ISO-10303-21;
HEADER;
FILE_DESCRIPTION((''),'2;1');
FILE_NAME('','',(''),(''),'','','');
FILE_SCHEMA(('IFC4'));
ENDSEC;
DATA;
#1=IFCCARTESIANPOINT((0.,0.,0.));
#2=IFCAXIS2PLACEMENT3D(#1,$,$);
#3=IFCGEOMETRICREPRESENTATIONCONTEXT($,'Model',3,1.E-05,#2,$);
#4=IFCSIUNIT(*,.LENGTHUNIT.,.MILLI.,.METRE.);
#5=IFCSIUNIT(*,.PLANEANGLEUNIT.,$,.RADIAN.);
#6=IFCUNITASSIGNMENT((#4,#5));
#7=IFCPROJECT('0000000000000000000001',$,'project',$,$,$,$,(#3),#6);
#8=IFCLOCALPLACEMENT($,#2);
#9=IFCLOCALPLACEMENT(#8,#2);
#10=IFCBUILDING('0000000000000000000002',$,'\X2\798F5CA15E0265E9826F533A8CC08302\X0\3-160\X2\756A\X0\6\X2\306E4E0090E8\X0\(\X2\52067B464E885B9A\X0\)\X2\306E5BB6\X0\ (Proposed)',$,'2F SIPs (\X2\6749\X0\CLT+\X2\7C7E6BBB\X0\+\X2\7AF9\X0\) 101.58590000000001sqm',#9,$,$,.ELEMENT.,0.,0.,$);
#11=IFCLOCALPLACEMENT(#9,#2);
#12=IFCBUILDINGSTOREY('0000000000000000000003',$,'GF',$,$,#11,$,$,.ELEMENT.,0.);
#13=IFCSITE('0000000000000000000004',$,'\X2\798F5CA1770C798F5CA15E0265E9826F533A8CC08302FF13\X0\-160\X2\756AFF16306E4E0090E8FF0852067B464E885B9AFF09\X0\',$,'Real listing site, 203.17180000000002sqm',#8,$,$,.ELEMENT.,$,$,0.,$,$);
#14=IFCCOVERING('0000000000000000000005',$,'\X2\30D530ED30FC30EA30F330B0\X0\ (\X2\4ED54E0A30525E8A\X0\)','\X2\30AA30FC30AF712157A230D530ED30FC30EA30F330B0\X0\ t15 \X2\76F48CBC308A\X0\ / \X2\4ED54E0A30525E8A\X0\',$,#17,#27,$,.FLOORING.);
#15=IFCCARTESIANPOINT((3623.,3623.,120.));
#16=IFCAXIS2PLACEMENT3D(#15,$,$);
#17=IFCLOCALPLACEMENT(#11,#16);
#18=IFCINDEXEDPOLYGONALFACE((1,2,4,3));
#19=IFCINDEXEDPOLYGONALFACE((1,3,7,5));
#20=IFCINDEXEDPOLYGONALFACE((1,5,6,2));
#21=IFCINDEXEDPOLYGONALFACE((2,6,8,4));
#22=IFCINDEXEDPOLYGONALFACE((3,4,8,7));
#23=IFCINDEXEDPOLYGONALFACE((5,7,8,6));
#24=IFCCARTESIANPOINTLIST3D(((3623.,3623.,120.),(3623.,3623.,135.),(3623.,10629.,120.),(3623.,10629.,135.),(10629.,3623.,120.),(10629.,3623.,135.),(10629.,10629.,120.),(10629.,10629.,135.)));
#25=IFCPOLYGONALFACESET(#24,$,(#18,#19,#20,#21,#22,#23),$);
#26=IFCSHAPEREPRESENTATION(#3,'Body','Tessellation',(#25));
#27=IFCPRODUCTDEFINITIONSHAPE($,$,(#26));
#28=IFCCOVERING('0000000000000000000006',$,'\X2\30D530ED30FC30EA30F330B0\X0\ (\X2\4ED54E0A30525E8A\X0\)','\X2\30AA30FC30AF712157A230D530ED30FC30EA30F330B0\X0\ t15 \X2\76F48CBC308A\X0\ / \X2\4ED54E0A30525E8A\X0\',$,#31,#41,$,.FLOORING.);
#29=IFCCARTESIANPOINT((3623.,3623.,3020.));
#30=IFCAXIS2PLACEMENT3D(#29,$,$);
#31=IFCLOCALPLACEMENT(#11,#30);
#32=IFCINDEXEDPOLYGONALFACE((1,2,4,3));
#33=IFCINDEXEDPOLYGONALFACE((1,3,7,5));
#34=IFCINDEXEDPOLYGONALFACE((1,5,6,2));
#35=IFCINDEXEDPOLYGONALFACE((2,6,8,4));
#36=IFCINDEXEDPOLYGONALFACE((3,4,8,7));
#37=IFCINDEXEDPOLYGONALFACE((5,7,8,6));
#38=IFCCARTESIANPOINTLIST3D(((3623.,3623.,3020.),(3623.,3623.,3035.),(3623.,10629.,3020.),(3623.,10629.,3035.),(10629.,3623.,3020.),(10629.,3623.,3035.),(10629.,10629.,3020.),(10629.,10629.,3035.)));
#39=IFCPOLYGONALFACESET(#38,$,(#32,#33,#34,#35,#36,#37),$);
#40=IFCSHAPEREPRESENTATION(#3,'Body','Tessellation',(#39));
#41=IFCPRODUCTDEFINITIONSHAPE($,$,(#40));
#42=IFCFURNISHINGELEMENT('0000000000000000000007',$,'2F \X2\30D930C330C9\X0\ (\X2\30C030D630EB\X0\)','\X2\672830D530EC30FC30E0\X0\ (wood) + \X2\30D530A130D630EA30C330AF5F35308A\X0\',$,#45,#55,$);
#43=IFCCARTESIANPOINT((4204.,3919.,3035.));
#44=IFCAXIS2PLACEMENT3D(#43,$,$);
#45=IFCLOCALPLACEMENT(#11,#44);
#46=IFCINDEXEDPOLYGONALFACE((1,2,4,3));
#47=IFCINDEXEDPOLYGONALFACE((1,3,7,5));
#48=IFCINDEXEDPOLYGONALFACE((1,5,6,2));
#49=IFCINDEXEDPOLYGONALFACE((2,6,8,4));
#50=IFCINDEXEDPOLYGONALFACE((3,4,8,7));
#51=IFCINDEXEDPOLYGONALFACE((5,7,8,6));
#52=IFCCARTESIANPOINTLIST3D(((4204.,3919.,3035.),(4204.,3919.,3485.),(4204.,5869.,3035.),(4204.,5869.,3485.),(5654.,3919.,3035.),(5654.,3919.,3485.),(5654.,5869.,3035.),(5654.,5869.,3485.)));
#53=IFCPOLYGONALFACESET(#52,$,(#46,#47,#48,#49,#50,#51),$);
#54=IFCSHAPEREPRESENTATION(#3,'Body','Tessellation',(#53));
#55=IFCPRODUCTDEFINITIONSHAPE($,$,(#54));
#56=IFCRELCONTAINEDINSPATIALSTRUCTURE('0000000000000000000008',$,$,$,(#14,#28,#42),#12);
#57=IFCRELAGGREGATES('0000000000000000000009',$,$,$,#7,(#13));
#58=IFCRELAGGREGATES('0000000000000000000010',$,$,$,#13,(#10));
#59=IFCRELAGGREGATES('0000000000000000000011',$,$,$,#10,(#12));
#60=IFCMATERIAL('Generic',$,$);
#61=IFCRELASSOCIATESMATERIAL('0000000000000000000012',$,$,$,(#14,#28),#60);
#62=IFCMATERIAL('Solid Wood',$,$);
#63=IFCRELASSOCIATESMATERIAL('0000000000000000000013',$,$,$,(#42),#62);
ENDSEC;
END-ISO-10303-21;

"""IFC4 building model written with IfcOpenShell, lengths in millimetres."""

from ifc_helpers import new_model, si_unit, frame, frame_2d, origin, place, context, project, spatial, rectangle, extrude, material, element, save


model = new_model("IFC4")

# Units and contexts
model_context = context("Model", 3, precision=1e-05, world=origin())
ifc_project = project(units=[si_unit("LENGTHUNIT", "METRE", prefix="MILLI"), si_unit("PLANEANGLEUNIT", "RADIAN")], contexts=[model_context])

# Site, building, storey
site_placement = place(None, origin())
site = spatial("IfcSite", under=ifc_project, at=site_placement, Name="福岡県福岡市早良区賀茂３-160番６の一部（分筆予定）", ObjectType="Real listing site, 203.17180000000002sqm", CompositionType="ELEMENT", RefElevation=0.0)
building_placement = place(site_placement, origin())
building = spatial("IfcBuilding", under=site, at=building_placement, Name="福岡市早良区賀茂3-160番6の一部(分筆予定)の家 (Proposed)", ObjectType="2F SIPs (杉CLT+籾殻+竹) 101.58590000000001sqm", CompositionType="ELEMENT", ElevationOfRefHeight=0.0, ElevationOfTerrain=0.0)
storey_placement = place(building_placement, origin())
storey = spatial("IfcBuildingStorey", under=building, at=storey_placement, Name="GF", CompositionType="ELEMENT", Elevation=0.0)

# Shared definitions
ifc_material_1 = material(Name="Solid Wood")

# Coverings
ifc_material_2 = material(Name="Generic")
covering_1_placement = place(storey_placement, frame((3623.0, 3623.0, 120.0)))
element("IfcCovering", 1, at=covering_1_placement, inside=storey, material=ifc_material_2, Name="フローリング (仕上げ床)", Description="オーク無垢フローリング t15 直貼り / 仕上げ床", PredefinedType="FLOORING", context=model_context, shape_type="SweptSolid", body=[
    extrude(rectangle(XDim=7006.0, YDim=7006.0, at=frame_2d((3503.0, 3503.0))), frame((3623.0, 3623.0, 120.0)), (0.0, 0.0, 1.0), 15.0),
])
covering_2_placement = place(storey_placement, frame((3623.0, 3623.0, 3020.0)))
element("IfcCovering", 2, at=covering_2_placement, inside=storey, material=ifc_material_2, Name="フローリング (仕上げ床)", Description="オーク無垢フローリング t15 直貼り / 仕上げ床", PredefinedType="FLOORING", context=model_context, shape_type="SweptSolid", body=[
    extrude(rectangle(XDim=7006.0, YDim=7006.0, at=frame_2d((3503.0, 3503.0))), frame((3623.0, 3623.0, 3020.0)), (0.0, 0.0, 1.0), 15.0),
])

# Furnishing element
furnishing_placement = place(storey_placement, frame((4204.0, 3919.0, 3035.0)))
element("IfcFurnishingElement", 3, at=furnishing_placement, inside=storey, material=ifc_material_1, Name="2F ベッド (ダブル)", Description="木フレーム (wood) + ファブリック張り", context=model_context, shape_type="SweptSolid", body=[
    extrude(rectangle(XDim=1450.0, YDim=1950.0, at=frame_2d((725.0, 975.0))), frame((4204.0, 3919.0, 3035.0)), (0.0, 0.0, 1.0), 450.0),
])

save(model, "model.ifc")
